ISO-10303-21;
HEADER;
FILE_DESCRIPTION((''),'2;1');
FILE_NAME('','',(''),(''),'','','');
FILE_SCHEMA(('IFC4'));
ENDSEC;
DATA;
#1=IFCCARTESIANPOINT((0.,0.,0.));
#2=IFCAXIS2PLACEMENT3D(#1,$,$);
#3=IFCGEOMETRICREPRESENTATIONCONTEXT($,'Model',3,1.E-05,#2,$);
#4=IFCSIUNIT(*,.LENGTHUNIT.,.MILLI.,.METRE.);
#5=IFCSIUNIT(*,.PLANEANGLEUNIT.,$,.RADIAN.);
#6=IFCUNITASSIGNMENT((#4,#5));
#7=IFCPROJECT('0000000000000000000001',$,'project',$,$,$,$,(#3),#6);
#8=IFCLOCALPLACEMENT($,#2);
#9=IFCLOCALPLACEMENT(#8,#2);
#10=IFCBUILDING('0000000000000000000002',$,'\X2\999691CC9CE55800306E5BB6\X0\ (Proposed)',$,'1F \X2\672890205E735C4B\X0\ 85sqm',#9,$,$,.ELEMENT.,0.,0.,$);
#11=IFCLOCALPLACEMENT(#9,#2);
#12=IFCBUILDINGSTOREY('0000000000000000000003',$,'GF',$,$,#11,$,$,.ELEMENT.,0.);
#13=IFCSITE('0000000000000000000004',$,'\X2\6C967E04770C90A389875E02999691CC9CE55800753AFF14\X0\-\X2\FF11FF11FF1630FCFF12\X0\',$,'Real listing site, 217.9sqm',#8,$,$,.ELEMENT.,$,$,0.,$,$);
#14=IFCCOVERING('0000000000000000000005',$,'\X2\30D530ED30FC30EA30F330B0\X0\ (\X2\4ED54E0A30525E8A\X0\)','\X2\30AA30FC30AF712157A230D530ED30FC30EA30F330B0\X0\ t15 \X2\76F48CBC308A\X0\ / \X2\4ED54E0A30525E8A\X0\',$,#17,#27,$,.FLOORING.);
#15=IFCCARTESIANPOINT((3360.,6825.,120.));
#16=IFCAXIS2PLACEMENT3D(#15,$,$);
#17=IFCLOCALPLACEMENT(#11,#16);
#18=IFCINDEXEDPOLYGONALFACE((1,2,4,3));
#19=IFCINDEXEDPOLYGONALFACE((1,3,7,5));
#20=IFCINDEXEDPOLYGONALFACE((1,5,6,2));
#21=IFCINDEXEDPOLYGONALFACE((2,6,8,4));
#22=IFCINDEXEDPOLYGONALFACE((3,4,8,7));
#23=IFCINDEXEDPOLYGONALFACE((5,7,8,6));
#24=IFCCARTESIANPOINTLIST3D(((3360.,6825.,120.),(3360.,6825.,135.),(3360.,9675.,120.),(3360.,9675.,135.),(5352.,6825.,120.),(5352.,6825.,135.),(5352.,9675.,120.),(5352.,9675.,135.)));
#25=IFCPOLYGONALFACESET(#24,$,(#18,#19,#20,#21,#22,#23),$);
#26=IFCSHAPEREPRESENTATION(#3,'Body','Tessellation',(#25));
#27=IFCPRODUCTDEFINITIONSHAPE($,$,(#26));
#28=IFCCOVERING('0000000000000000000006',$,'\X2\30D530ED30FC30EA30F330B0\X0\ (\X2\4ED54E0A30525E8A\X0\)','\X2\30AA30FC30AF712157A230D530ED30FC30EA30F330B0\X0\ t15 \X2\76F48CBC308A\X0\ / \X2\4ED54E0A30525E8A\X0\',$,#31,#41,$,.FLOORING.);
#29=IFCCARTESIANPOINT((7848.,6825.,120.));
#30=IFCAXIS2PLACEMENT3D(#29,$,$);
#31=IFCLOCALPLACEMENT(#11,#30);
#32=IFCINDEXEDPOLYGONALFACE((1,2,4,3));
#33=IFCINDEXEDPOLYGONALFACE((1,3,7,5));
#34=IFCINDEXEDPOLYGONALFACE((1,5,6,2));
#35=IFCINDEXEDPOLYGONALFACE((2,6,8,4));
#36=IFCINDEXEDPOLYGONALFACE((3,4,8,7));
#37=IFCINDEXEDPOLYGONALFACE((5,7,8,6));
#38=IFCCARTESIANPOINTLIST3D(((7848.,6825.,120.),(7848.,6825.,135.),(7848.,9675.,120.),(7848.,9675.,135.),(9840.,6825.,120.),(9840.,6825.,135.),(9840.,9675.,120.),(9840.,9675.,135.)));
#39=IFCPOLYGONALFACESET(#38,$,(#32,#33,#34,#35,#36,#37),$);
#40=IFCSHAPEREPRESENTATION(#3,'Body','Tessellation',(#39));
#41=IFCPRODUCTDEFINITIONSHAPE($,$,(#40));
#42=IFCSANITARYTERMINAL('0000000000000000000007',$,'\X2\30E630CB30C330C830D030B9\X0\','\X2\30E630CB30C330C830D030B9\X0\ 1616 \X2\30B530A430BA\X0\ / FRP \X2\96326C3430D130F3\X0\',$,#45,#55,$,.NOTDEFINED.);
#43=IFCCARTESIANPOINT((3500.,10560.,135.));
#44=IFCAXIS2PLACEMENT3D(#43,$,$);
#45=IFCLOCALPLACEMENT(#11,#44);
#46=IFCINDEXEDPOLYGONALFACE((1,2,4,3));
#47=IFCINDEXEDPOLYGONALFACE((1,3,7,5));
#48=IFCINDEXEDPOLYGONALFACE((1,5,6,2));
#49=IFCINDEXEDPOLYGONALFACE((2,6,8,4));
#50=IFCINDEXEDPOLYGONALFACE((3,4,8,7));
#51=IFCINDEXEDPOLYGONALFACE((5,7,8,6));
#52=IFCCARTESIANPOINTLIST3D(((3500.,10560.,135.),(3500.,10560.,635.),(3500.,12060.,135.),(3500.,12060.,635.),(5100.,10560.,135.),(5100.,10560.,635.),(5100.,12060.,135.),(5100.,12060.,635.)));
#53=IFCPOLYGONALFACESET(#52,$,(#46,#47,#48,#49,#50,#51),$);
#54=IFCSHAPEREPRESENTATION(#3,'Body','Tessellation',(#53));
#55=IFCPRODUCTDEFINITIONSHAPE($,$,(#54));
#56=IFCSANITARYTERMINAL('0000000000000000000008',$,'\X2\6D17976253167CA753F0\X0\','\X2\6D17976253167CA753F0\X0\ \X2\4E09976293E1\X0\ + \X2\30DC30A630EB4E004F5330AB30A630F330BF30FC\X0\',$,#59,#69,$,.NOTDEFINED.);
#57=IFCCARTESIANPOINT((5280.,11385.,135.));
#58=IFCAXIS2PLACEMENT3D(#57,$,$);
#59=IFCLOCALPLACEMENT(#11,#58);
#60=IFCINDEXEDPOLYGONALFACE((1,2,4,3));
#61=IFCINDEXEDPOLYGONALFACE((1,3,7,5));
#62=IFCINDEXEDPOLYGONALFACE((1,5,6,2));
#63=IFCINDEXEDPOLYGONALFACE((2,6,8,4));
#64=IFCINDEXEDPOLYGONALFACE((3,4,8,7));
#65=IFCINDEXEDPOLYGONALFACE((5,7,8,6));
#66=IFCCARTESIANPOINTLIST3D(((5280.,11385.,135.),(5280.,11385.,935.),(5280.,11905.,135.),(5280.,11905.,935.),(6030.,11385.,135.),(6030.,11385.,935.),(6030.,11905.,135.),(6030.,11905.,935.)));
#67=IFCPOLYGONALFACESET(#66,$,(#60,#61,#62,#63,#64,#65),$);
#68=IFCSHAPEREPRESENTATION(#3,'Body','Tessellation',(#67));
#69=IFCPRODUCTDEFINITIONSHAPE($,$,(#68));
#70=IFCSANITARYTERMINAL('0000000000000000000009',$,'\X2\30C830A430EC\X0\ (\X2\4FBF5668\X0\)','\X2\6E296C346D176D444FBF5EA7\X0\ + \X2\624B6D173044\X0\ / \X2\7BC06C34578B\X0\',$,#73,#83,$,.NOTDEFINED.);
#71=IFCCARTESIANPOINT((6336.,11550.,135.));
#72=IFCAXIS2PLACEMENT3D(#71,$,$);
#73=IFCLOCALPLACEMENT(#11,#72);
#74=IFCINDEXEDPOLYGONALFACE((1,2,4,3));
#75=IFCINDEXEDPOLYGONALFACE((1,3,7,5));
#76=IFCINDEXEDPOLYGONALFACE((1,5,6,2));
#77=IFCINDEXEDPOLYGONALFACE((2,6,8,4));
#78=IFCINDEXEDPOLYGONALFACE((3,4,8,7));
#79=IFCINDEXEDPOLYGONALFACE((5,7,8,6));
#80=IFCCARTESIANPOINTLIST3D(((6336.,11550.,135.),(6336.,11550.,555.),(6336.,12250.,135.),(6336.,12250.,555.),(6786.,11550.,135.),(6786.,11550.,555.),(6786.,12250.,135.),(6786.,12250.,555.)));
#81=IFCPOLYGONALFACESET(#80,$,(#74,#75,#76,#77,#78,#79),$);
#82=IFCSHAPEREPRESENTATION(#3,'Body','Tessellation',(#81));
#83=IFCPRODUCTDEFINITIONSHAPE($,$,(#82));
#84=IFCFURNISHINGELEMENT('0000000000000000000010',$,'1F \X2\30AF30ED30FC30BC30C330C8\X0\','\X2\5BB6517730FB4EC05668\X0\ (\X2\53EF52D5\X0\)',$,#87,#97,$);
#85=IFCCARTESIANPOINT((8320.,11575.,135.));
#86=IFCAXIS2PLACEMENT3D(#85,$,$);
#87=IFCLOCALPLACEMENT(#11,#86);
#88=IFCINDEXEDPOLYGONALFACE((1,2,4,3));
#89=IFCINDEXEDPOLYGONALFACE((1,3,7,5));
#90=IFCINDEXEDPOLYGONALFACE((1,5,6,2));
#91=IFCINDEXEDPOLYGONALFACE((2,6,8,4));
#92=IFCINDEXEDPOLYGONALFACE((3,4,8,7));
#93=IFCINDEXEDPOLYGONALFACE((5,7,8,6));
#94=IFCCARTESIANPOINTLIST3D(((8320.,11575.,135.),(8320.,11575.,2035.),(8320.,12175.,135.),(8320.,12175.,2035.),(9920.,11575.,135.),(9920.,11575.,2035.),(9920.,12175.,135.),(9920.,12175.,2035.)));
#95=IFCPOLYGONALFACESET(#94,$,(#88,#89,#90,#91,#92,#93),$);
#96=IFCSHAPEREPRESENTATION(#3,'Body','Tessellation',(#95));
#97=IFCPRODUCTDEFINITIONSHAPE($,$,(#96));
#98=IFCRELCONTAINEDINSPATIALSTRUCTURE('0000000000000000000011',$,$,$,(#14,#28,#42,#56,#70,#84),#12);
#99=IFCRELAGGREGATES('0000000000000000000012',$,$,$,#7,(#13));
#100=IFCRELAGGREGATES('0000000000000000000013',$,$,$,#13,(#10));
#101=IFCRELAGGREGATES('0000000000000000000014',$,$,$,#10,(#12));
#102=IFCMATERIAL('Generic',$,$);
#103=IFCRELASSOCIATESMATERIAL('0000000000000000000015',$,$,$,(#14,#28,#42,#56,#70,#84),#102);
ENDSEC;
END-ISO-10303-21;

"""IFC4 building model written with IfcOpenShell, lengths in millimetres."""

from ifc_helpers import new_model, si_unit, frame, frame_2d, origin, place, context, project, spatial, rectangle, extrude, material, element, save


model = new_model("IFC4")

# Units and contexts
model_context = context("Model", 3, precision=1e-05, world=origin())
ifc_project = project(units=[si_unit("LENGTHUNIT", "METRE", prefix="MILLI"), si_unit("PLANEANGLEUNIT", "RADIAN")], contexts=[model_context])

# Site, building, storey
site_placement = place(None, origin())
site = spatial("IfcSite", under=ifc_project, at=site_placement, Name="沖縄県那覇市首里鳥堀町４-１１６ー２", ObjectType="Real listing site, 217.9sqm", CompositionType="ELEMENT", RefElevation=0.0)
building_placement = place(site_placement, origin())
building = spatial("IfcBuilding", under=site, at=building_placement, Name="首里鳥堀の家 (Proposed)", ObjectType="1F 木造平屋 85sqm", CompositionType="ELEMENT", ElevationOfRefHeight=0.0, ElevationOfTerrain=0.0)
storey_placement = place(building_placement, origin())
storey = spatial("IfcBuildingStorey", under=building, at=storey_placement, Name="GF", CompositionType="ELEMENT", Elevation=0.0)

# Coverings
ifc_material_1 = material(Name="Generic")
covering_1_placement = place(storey_placement, frame((3360.0, 6825.0, 120.0)))
element("IfcCovering", 1, at=covering_1_placement, inside=storey, material=ifc_material_1, Name="フローリング (仕上げ床)", Description="オーク無垢フローリング t15 直貼り / 仕上げ床", PredefinedType="FLOORING", context=model_context, shape_type="SweptSolid", body=[
    extrude(rectangle(XDim=1992.0, YDim=2850.0, at=frame_2d((996.0, 1425.0))), frame((3360.0, 6825.0, 120.0)), (0.0, 0.0, 1.0), 15.0),
])
covering_2_placement = place(storey_placement, frame((7848.0, 6825.0, 120.0)))
element("IfcCovering", 2, at=covering_2_placement, inside=storey, material=ifc_material_1, Name="フローリング (仕上げ床)", Description="オーク無垢フローリング t15 直貼り / 仕上げ床", PredefinedType="FLOORING", context=model_context, shape_type="SweptSolid", body=[
    extrude(rectangle(XDim=1992.0, YDim=2850.0, at=frame_2d((996.0, 1425.0))), frame((7848.0, 6825.0, 120.0)), (0.0, 0.0, 1.0), 15.0),
])

# Sanitary terminals
sanitary_terminal_1_placement = place(storey_placement, frame((3500.0, 10560.0, 135.0)))
element("IfcSanitaryTerminal", 3, at=sanitary_terminal_1_placement, inside=storey, material=ifc_material_1, Name="ユニットバス", Description="ユニットバス 1616 サイズ / FRP 防水パン", PredefinedType="NOTDEFINED", context=model_context, shape_type="SweptSolid", body=[
    extrude(rectangle(XDim=1600.0, YDim=1500.0, at=frame_2d((800.0, 750.0))), frame((3500.0, 10560.0, 135.0)), (0.0, 0.0, 1.0), 500.0),
])
sanitary_terminal_2_placement = place(storey_placement, frame((5280.0, 11385.0, 135.0)))
element("IfcSanitaryTerminal", 4, at=sanitary_terminal_2_placement, inside=storey, material=ifc_material_1, Name="洗面化粧台", Description="洗面化粧台 三面鏡 + ボウル一体カウンター", PredefinedType="NOTDEFINED", context=model_context, shape_type="SweptSolid", body=[
    extrude(rectangle(XDim=750.0, YDim=520.0, at=frame_2d((375.0, 260.0))), frame((5280.0, 11385.0, 135.0)), (0.0, 0.0, 1.0), 800.0),
])
sanitary_terminal_3_placement = place(storey_placement, frame((6336.0, 11550.0, 135.0)))
element("IfcSanitaryTerminal", 5, at=sanitary_terminal_3_placement, inside=storey, material=ifc_material_1, Name="トイレ (便器)", Description="温水洗浄便座 + 手洗い / 節水型", PredefinedType="NOTDEFINED", context=model_context, shape_type="SweptSolid", body=[
    extrude(rectangle(XDim=450.0, YDim=700.0, at=frame_2d((225.0, 350.0))), frame((6336.0, 11550.0, 135.0)), (0.0, 0.0, 1.0), 420.0),
])

# Furnishing element
furnishing_placement = place(storey_placement, frame((8320.0, 11575.0, 135.0)))
element("IfcFurnishingElement", 6, at=furnishing_placement, inside=storey, material=ifc_material_1, Name="1F クローゼット", Description="家具・什器 (可動)", context=model_context, shape_type="SweptSolid", body=[
    extrude(rectangle(XDim=1600.0, YDim=600.0, at=frame_2d((800.0, 300.0))), frame((8320.0, 11575.0, 135.0)), (0.0, 0.0, 1.0), 1900.0),
])

save(model, "model.ifc")
